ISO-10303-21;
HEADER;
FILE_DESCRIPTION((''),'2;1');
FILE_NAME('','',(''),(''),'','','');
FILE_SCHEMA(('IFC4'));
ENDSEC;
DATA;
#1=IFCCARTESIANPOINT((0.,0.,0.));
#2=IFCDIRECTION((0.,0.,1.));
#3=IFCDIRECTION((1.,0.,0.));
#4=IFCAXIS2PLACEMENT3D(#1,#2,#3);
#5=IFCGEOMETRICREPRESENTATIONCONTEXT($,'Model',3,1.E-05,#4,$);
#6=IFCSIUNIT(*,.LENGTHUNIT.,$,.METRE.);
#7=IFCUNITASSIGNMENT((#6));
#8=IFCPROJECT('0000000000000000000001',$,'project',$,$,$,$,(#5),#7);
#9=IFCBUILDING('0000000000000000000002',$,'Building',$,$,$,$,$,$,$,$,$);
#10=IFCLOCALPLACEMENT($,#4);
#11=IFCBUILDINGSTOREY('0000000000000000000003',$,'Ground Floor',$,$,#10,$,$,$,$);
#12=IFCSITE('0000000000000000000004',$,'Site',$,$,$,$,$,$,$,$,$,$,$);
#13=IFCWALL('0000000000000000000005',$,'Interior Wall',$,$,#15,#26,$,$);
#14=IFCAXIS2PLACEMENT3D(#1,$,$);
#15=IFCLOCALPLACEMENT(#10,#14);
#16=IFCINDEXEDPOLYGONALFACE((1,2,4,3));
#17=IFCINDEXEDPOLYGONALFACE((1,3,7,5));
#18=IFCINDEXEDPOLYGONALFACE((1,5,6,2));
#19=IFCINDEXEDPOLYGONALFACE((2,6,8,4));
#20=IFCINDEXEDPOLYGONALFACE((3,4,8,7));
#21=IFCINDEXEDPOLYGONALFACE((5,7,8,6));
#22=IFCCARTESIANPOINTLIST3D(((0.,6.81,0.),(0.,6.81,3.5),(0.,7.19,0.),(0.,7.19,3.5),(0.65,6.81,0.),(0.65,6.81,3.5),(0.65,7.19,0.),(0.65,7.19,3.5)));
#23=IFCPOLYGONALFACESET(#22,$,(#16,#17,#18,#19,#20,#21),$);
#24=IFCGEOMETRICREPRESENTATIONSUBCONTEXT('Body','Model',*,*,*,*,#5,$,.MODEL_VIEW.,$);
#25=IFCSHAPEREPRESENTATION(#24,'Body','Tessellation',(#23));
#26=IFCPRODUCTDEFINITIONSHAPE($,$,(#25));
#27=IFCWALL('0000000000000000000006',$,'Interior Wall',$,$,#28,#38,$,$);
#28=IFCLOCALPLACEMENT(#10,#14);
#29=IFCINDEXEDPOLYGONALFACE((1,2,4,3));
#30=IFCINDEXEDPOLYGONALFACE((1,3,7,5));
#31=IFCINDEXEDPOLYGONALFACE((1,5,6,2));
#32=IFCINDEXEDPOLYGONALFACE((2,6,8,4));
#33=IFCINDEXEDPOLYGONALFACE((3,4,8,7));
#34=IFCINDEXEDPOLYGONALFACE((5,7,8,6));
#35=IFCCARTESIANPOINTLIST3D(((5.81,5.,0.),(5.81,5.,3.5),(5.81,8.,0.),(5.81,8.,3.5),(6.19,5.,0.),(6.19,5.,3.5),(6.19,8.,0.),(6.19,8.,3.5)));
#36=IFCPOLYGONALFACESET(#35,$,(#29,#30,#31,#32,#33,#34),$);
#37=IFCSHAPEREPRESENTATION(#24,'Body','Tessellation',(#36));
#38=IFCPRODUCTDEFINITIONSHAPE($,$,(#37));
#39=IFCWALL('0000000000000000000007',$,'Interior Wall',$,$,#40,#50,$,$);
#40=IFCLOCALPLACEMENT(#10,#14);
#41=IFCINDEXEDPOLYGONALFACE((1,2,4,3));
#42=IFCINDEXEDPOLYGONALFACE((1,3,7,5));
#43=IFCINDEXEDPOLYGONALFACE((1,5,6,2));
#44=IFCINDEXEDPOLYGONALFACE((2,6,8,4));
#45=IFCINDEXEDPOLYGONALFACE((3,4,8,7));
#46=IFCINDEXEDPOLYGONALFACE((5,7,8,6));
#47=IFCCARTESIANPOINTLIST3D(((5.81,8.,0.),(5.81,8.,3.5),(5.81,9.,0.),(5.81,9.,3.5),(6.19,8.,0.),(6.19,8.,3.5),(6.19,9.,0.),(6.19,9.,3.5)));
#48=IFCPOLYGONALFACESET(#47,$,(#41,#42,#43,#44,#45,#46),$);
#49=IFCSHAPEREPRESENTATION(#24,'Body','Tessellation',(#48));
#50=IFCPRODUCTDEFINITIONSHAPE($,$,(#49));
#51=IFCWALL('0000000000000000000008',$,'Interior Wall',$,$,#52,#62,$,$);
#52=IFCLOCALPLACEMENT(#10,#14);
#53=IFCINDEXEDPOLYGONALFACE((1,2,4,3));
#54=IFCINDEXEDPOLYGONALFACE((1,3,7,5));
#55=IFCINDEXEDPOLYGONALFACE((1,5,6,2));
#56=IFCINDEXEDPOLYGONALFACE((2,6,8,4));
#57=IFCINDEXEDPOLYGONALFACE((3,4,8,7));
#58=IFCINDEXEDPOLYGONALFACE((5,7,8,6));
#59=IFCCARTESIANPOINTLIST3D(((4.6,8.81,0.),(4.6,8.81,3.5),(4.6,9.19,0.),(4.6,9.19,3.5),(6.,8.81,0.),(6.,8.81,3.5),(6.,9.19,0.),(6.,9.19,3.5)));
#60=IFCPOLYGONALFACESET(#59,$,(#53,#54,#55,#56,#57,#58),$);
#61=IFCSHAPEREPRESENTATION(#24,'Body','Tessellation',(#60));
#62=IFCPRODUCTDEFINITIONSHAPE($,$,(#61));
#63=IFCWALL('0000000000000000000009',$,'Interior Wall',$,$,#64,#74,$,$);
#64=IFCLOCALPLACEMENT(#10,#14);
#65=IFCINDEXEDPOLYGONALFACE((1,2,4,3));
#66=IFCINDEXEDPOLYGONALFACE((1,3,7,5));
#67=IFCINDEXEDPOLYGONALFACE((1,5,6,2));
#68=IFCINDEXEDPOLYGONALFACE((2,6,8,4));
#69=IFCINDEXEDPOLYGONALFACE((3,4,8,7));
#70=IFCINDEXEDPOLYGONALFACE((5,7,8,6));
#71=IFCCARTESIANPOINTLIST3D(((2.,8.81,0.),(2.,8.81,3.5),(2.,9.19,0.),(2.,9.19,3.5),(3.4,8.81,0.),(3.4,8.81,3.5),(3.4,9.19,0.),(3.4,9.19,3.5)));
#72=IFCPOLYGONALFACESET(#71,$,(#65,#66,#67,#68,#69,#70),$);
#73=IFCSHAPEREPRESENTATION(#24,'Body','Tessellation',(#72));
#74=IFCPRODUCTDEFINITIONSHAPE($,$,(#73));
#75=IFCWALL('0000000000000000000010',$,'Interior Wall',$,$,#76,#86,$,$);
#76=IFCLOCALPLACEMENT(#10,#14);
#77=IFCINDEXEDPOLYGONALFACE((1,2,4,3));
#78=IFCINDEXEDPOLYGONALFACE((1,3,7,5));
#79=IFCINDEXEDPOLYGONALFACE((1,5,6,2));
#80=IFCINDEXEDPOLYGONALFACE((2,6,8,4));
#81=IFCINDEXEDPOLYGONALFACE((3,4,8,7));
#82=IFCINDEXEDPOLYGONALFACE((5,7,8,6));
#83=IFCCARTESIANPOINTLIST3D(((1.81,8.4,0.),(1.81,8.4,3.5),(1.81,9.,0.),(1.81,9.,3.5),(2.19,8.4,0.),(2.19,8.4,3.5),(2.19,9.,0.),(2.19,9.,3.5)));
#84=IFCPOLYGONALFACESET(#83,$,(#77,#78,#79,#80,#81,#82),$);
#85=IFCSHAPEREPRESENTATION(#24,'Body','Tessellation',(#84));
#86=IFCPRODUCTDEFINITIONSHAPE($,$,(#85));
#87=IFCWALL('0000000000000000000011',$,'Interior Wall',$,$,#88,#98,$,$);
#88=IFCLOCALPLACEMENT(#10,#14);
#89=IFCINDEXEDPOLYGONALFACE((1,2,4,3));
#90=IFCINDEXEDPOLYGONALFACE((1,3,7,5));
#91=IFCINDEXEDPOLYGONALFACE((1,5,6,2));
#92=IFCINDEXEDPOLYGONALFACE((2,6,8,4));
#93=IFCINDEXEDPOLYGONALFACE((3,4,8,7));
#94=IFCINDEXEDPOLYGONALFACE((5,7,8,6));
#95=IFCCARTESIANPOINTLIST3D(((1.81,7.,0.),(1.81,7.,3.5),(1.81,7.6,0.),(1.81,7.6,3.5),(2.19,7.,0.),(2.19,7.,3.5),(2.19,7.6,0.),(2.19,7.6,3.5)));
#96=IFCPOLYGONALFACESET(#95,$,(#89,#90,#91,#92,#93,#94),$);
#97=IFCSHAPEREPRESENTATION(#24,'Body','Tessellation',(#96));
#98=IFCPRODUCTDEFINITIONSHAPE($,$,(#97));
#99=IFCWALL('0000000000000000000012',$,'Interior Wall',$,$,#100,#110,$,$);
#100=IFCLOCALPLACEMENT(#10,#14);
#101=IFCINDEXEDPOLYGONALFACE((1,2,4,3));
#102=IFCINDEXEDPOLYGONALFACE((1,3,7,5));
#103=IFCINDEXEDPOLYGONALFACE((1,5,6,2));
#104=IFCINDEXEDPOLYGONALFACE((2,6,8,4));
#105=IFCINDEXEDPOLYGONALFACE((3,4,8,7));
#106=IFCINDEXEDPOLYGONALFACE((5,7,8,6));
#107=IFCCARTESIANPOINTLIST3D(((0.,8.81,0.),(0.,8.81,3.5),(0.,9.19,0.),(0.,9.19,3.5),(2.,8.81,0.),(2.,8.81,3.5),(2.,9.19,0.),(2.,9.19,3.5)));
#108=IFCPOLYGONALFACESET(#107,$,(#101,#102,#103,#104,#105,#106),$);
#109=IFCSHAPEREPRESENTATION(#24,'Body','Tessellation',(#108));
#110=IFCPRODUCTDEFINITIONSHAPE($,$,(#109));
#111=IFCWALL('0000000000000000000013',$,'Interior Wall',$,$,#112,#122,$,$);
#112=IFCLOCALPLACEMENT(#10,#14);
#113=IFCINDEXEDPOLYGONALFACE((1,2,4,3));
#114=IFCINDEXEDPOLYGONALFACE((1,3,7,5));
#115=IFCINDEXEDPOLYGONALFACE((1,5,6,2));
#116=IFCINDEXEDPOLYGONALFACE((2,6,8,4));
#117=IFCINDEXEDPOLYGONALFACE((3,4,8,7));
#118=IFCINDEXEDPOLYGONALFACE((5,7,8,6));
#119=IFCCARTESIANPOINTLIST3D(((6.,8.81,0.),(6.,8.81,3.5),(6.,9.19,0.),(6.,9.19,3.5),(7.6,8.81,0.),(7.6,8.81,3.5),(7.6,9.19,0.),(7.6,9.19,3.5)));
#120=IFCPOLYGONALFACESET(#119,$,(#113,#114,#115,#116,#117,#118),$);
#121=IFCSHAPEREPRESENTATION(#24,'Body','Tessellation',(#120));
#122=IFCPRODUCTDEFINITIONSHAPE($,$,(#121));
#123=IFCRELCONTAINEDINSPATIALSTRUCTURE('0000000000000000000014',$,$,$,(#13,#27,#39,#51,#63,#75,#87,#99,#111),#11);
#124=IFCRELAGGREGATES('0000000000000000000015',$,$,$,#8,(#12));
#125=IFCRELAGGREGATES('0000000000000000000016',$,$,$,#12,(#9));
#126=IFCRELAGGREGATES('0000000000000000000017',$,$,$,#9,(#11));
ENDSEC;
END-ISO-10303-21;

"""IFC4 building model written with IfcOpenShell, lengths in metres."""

from ifc_helpers import new_model, si_unit, frame, origin_with_axes, place, context, subcontext, project, spatial, indexed_curve, outline, extrude, element, save


model = new_model("IFC4")

# Units and contexts
model_context = context("Model", 3, precision=1e-05, world=origin_with_axes())
body_context = subcontext(model_context, "Body", "Model", "MODEL_VIEW")
ifc_project = project(units=[si_unit("LENGTHUNIT", "METRE")], contexts=[model_context])

# Site, building, storey
site = spatial("IfcSite", under=ifc_project, Name="Site")
building = spatial("IfcBuilding", under=site, Name="Building")
storey_placement = place(None, origin_with_axes())
storey = spatial("IfcBuildingStorey", under=building, at=storey_placement, Name="Ground Floor")

# Walls
for number, where, z_axis, x_axis, name in (
    (1, (0.65, 7.0, 0.0), (0.0, 0.0, 1.0), (-1.0, 0.0, 0.0), "Interior Wall"),
):
    element("IfcWall", number, at=place(storey_placement, frame(where, z_axis=z_axis, x_axis=x_axis)), inside=storey, Name=name, context=body_context, shape_type="SweptSolid", body=[
        extrude(outline(indexed_curve([(0.0, 0.0), (0.0, 0.38), (0.65, 0.38), (0.65, 0.0), (0.0, 0.0)], self_intersect=False)), frame((0.0, -0.19, 0.0), z_axis=(0.0, 0.0, 1.0), x_axis=(1.0, 0.0, 0.0)), (0.0, 0.0, 1.0), 3.5),
    ])
wall_1_placement = place(storey_placement, frame((6.0, 5.0, 0.0), z_axis=(0.0, 0.0, 1.0), x_axis=(0.0, 1.0, 0.0)))
element("IfcWall", 2, at=wall_1_placement, inside=storey, Name="Interior Wall", context=body_context, shape_type="SweptSolid", body=[
    extrude(outline(indexed_curve([(0.0, 0.0), (0.0, 0.38), (3.0, 0.38), (3.0, 0.0), (0.0, 0.0)], self_intersect=False)), frame((0.0, -0.19, 0.0), z_axis=(0.0, 0.0, 1.0), x_axis=(1.0, 0.0, 0.0)), (0.0, 0.0, 1.0), 3.5),
])
wall_2_placement = place(storey_placement, frame((6.0, 8.0, 0.0), z_axis=(0.0, 0.0, 1.0), x_axis=(0.0, 1.0, 0.0)))
element("IfcWall", 3, at=wall_2_placement, inside=storey, Name="Interior Wall", context=body_context, shape_type="SweptSolid", body=[
    extrude(outline(indexed_curve([(0.0, 0.0), (0.0, 0.38), (1.0, 0.38), (1.0, 0.0), (0.0, 0.0)], self_intersect=False)), frame((0.0, -0.19, 0.0), z_axis=(0.0, 0.0, 1.0), x_axis=(1.0, 0.0, 0.0)), (0.0, 0.0, 1.0), 3.5),
])
wall_3_placement = place(storey_placement, frame((6.0, 9.0, 0.0), z_axis=(0.0, 0.0, 1.0), x_axis=(-1.0, 0.0, 0.0)))
element("IfcWall", 4, at=wall_3_placement, inside=storey, Name="Interior Wall", context=body_context, shape_type="SweptSolid", body=[
    extrude(outline(indexed_curve([(0.0, 0.0), (0.0, 0.38), (1.4, 0.38), (1.4, 0.0), (0.0, 0.0)], self_intersect=False)), frame((0.0, -0.19, 0.0), z_axis=(0.0, 0.0, 1.0), x_axis=(1.0, 0.0, 0.0)), (0.0, 0.0, 1.0), 3.5),
])
wall_4_placement = place(storey_placement, frame((3.4, 9.0, 0.0), z_axis=(0.0, 0.0, 1.0), x_axis=(-1.0, 0.0, 0.0)))
element("IfcWall", 5, at=wall_4_placement, inside=storey, Name="Interior Wall", context=body_context, shape_type="SweptSolid", body=[
    extrude(outline(indexed_curve([(0.0, 0.0), (0.0, 0.38), (1.4, 0.38), (1.4, 0.0), (0.0, 0.0)], self_intersect=False)), frame((0.0, -0.19, 0.0), z_axis=(0.0, 0.0, 1.0), x_axis=(1.0, 0.0, 0.0)), (0.0, 0.0, 1.0), 3.5),
])
for number, where, z_axis, x_axis, name in (
    (6, (2.0, 9.0, 0.0), (0.0, 0.0, 1.0), (0.0, -1.0, 0.0), "Interior Wall"),
    (7, (2.0, 7.6, 0.0), (0.0, 0.0, 1.0), (0.0, -1.0, 0.0), "Interior Wall"),
):
    element("IfcWall", number, at=place(storey_placement, frame(where, z_axis=z_axis, x_axis=x_axis)), inside=storey, Name=name, context=body_context, shape_type="SweptSolid", body=[
        extrude(outline(indexed_curve([(0.0, 0.0), (0.0, 0.38), (0.6, 0.38), (0.6, 0.0), (0.0, 0.0)], self_intersect=False)), frame((0.0, -0.19, 0.0), z_axis=(0.0, 0.0, 1.0), x_axis=(1.0, 0.0, 0.0)), (0.0, 0.0, 1.0), 3.5),
    ])
wall_5_placement = place(storey_placement, frame((2.0, 9.0, 0.0), z_axis=(0.0, 0.0, 1.0), x_axis=(-1.0, 0.0, 0.0)))
element("IfcWall", 8, at=wall_5_placement, inside=storey, Name="Interior Wall", context=body_context, shape_type="SweptSolid", body=[
    extrude(outline(indexed_curve([(0.0, 0.0), (0.0, 0.38), (2.0, 0.38), (2.0, 0.0), (0.0, 0.0)], self_intersect=False)), frame((0.0, -0.19, 0.0), z_axis=(0.0, 0.0, 1.0), x_axis=(1.0, 0.0, 0.0)), (0.0, 0.0, 1.0), 3.5),
])
wall_6_placement = place(storey_placement, frame((6.0, 9.0, 0.0), z_axis=(0.0, 0.0, 1.0), x_axis=(1.0, 0.0, 0.0)))
element("IfcWall", 9, at=wall_6_placement, inside=storey, Name="Interior Wall", context=body_context, shape_type="SweptSolid", body=[
    extrude(outline(indexed_curve([(0.0, 0.0), (0.0, 0.38), (1.6, 0.38), (1.6, 0.0), (0.0, 0.0)], self_intersect=False)), frame((0.0, -0.19, 0.0), z_axis=(0.0, 0.0, 1.0), x_axis=(1.0, 0.0, 0.0)), (0.0, 0.0, 1.0), 3.5),
])

save(model, "model.ifc")
